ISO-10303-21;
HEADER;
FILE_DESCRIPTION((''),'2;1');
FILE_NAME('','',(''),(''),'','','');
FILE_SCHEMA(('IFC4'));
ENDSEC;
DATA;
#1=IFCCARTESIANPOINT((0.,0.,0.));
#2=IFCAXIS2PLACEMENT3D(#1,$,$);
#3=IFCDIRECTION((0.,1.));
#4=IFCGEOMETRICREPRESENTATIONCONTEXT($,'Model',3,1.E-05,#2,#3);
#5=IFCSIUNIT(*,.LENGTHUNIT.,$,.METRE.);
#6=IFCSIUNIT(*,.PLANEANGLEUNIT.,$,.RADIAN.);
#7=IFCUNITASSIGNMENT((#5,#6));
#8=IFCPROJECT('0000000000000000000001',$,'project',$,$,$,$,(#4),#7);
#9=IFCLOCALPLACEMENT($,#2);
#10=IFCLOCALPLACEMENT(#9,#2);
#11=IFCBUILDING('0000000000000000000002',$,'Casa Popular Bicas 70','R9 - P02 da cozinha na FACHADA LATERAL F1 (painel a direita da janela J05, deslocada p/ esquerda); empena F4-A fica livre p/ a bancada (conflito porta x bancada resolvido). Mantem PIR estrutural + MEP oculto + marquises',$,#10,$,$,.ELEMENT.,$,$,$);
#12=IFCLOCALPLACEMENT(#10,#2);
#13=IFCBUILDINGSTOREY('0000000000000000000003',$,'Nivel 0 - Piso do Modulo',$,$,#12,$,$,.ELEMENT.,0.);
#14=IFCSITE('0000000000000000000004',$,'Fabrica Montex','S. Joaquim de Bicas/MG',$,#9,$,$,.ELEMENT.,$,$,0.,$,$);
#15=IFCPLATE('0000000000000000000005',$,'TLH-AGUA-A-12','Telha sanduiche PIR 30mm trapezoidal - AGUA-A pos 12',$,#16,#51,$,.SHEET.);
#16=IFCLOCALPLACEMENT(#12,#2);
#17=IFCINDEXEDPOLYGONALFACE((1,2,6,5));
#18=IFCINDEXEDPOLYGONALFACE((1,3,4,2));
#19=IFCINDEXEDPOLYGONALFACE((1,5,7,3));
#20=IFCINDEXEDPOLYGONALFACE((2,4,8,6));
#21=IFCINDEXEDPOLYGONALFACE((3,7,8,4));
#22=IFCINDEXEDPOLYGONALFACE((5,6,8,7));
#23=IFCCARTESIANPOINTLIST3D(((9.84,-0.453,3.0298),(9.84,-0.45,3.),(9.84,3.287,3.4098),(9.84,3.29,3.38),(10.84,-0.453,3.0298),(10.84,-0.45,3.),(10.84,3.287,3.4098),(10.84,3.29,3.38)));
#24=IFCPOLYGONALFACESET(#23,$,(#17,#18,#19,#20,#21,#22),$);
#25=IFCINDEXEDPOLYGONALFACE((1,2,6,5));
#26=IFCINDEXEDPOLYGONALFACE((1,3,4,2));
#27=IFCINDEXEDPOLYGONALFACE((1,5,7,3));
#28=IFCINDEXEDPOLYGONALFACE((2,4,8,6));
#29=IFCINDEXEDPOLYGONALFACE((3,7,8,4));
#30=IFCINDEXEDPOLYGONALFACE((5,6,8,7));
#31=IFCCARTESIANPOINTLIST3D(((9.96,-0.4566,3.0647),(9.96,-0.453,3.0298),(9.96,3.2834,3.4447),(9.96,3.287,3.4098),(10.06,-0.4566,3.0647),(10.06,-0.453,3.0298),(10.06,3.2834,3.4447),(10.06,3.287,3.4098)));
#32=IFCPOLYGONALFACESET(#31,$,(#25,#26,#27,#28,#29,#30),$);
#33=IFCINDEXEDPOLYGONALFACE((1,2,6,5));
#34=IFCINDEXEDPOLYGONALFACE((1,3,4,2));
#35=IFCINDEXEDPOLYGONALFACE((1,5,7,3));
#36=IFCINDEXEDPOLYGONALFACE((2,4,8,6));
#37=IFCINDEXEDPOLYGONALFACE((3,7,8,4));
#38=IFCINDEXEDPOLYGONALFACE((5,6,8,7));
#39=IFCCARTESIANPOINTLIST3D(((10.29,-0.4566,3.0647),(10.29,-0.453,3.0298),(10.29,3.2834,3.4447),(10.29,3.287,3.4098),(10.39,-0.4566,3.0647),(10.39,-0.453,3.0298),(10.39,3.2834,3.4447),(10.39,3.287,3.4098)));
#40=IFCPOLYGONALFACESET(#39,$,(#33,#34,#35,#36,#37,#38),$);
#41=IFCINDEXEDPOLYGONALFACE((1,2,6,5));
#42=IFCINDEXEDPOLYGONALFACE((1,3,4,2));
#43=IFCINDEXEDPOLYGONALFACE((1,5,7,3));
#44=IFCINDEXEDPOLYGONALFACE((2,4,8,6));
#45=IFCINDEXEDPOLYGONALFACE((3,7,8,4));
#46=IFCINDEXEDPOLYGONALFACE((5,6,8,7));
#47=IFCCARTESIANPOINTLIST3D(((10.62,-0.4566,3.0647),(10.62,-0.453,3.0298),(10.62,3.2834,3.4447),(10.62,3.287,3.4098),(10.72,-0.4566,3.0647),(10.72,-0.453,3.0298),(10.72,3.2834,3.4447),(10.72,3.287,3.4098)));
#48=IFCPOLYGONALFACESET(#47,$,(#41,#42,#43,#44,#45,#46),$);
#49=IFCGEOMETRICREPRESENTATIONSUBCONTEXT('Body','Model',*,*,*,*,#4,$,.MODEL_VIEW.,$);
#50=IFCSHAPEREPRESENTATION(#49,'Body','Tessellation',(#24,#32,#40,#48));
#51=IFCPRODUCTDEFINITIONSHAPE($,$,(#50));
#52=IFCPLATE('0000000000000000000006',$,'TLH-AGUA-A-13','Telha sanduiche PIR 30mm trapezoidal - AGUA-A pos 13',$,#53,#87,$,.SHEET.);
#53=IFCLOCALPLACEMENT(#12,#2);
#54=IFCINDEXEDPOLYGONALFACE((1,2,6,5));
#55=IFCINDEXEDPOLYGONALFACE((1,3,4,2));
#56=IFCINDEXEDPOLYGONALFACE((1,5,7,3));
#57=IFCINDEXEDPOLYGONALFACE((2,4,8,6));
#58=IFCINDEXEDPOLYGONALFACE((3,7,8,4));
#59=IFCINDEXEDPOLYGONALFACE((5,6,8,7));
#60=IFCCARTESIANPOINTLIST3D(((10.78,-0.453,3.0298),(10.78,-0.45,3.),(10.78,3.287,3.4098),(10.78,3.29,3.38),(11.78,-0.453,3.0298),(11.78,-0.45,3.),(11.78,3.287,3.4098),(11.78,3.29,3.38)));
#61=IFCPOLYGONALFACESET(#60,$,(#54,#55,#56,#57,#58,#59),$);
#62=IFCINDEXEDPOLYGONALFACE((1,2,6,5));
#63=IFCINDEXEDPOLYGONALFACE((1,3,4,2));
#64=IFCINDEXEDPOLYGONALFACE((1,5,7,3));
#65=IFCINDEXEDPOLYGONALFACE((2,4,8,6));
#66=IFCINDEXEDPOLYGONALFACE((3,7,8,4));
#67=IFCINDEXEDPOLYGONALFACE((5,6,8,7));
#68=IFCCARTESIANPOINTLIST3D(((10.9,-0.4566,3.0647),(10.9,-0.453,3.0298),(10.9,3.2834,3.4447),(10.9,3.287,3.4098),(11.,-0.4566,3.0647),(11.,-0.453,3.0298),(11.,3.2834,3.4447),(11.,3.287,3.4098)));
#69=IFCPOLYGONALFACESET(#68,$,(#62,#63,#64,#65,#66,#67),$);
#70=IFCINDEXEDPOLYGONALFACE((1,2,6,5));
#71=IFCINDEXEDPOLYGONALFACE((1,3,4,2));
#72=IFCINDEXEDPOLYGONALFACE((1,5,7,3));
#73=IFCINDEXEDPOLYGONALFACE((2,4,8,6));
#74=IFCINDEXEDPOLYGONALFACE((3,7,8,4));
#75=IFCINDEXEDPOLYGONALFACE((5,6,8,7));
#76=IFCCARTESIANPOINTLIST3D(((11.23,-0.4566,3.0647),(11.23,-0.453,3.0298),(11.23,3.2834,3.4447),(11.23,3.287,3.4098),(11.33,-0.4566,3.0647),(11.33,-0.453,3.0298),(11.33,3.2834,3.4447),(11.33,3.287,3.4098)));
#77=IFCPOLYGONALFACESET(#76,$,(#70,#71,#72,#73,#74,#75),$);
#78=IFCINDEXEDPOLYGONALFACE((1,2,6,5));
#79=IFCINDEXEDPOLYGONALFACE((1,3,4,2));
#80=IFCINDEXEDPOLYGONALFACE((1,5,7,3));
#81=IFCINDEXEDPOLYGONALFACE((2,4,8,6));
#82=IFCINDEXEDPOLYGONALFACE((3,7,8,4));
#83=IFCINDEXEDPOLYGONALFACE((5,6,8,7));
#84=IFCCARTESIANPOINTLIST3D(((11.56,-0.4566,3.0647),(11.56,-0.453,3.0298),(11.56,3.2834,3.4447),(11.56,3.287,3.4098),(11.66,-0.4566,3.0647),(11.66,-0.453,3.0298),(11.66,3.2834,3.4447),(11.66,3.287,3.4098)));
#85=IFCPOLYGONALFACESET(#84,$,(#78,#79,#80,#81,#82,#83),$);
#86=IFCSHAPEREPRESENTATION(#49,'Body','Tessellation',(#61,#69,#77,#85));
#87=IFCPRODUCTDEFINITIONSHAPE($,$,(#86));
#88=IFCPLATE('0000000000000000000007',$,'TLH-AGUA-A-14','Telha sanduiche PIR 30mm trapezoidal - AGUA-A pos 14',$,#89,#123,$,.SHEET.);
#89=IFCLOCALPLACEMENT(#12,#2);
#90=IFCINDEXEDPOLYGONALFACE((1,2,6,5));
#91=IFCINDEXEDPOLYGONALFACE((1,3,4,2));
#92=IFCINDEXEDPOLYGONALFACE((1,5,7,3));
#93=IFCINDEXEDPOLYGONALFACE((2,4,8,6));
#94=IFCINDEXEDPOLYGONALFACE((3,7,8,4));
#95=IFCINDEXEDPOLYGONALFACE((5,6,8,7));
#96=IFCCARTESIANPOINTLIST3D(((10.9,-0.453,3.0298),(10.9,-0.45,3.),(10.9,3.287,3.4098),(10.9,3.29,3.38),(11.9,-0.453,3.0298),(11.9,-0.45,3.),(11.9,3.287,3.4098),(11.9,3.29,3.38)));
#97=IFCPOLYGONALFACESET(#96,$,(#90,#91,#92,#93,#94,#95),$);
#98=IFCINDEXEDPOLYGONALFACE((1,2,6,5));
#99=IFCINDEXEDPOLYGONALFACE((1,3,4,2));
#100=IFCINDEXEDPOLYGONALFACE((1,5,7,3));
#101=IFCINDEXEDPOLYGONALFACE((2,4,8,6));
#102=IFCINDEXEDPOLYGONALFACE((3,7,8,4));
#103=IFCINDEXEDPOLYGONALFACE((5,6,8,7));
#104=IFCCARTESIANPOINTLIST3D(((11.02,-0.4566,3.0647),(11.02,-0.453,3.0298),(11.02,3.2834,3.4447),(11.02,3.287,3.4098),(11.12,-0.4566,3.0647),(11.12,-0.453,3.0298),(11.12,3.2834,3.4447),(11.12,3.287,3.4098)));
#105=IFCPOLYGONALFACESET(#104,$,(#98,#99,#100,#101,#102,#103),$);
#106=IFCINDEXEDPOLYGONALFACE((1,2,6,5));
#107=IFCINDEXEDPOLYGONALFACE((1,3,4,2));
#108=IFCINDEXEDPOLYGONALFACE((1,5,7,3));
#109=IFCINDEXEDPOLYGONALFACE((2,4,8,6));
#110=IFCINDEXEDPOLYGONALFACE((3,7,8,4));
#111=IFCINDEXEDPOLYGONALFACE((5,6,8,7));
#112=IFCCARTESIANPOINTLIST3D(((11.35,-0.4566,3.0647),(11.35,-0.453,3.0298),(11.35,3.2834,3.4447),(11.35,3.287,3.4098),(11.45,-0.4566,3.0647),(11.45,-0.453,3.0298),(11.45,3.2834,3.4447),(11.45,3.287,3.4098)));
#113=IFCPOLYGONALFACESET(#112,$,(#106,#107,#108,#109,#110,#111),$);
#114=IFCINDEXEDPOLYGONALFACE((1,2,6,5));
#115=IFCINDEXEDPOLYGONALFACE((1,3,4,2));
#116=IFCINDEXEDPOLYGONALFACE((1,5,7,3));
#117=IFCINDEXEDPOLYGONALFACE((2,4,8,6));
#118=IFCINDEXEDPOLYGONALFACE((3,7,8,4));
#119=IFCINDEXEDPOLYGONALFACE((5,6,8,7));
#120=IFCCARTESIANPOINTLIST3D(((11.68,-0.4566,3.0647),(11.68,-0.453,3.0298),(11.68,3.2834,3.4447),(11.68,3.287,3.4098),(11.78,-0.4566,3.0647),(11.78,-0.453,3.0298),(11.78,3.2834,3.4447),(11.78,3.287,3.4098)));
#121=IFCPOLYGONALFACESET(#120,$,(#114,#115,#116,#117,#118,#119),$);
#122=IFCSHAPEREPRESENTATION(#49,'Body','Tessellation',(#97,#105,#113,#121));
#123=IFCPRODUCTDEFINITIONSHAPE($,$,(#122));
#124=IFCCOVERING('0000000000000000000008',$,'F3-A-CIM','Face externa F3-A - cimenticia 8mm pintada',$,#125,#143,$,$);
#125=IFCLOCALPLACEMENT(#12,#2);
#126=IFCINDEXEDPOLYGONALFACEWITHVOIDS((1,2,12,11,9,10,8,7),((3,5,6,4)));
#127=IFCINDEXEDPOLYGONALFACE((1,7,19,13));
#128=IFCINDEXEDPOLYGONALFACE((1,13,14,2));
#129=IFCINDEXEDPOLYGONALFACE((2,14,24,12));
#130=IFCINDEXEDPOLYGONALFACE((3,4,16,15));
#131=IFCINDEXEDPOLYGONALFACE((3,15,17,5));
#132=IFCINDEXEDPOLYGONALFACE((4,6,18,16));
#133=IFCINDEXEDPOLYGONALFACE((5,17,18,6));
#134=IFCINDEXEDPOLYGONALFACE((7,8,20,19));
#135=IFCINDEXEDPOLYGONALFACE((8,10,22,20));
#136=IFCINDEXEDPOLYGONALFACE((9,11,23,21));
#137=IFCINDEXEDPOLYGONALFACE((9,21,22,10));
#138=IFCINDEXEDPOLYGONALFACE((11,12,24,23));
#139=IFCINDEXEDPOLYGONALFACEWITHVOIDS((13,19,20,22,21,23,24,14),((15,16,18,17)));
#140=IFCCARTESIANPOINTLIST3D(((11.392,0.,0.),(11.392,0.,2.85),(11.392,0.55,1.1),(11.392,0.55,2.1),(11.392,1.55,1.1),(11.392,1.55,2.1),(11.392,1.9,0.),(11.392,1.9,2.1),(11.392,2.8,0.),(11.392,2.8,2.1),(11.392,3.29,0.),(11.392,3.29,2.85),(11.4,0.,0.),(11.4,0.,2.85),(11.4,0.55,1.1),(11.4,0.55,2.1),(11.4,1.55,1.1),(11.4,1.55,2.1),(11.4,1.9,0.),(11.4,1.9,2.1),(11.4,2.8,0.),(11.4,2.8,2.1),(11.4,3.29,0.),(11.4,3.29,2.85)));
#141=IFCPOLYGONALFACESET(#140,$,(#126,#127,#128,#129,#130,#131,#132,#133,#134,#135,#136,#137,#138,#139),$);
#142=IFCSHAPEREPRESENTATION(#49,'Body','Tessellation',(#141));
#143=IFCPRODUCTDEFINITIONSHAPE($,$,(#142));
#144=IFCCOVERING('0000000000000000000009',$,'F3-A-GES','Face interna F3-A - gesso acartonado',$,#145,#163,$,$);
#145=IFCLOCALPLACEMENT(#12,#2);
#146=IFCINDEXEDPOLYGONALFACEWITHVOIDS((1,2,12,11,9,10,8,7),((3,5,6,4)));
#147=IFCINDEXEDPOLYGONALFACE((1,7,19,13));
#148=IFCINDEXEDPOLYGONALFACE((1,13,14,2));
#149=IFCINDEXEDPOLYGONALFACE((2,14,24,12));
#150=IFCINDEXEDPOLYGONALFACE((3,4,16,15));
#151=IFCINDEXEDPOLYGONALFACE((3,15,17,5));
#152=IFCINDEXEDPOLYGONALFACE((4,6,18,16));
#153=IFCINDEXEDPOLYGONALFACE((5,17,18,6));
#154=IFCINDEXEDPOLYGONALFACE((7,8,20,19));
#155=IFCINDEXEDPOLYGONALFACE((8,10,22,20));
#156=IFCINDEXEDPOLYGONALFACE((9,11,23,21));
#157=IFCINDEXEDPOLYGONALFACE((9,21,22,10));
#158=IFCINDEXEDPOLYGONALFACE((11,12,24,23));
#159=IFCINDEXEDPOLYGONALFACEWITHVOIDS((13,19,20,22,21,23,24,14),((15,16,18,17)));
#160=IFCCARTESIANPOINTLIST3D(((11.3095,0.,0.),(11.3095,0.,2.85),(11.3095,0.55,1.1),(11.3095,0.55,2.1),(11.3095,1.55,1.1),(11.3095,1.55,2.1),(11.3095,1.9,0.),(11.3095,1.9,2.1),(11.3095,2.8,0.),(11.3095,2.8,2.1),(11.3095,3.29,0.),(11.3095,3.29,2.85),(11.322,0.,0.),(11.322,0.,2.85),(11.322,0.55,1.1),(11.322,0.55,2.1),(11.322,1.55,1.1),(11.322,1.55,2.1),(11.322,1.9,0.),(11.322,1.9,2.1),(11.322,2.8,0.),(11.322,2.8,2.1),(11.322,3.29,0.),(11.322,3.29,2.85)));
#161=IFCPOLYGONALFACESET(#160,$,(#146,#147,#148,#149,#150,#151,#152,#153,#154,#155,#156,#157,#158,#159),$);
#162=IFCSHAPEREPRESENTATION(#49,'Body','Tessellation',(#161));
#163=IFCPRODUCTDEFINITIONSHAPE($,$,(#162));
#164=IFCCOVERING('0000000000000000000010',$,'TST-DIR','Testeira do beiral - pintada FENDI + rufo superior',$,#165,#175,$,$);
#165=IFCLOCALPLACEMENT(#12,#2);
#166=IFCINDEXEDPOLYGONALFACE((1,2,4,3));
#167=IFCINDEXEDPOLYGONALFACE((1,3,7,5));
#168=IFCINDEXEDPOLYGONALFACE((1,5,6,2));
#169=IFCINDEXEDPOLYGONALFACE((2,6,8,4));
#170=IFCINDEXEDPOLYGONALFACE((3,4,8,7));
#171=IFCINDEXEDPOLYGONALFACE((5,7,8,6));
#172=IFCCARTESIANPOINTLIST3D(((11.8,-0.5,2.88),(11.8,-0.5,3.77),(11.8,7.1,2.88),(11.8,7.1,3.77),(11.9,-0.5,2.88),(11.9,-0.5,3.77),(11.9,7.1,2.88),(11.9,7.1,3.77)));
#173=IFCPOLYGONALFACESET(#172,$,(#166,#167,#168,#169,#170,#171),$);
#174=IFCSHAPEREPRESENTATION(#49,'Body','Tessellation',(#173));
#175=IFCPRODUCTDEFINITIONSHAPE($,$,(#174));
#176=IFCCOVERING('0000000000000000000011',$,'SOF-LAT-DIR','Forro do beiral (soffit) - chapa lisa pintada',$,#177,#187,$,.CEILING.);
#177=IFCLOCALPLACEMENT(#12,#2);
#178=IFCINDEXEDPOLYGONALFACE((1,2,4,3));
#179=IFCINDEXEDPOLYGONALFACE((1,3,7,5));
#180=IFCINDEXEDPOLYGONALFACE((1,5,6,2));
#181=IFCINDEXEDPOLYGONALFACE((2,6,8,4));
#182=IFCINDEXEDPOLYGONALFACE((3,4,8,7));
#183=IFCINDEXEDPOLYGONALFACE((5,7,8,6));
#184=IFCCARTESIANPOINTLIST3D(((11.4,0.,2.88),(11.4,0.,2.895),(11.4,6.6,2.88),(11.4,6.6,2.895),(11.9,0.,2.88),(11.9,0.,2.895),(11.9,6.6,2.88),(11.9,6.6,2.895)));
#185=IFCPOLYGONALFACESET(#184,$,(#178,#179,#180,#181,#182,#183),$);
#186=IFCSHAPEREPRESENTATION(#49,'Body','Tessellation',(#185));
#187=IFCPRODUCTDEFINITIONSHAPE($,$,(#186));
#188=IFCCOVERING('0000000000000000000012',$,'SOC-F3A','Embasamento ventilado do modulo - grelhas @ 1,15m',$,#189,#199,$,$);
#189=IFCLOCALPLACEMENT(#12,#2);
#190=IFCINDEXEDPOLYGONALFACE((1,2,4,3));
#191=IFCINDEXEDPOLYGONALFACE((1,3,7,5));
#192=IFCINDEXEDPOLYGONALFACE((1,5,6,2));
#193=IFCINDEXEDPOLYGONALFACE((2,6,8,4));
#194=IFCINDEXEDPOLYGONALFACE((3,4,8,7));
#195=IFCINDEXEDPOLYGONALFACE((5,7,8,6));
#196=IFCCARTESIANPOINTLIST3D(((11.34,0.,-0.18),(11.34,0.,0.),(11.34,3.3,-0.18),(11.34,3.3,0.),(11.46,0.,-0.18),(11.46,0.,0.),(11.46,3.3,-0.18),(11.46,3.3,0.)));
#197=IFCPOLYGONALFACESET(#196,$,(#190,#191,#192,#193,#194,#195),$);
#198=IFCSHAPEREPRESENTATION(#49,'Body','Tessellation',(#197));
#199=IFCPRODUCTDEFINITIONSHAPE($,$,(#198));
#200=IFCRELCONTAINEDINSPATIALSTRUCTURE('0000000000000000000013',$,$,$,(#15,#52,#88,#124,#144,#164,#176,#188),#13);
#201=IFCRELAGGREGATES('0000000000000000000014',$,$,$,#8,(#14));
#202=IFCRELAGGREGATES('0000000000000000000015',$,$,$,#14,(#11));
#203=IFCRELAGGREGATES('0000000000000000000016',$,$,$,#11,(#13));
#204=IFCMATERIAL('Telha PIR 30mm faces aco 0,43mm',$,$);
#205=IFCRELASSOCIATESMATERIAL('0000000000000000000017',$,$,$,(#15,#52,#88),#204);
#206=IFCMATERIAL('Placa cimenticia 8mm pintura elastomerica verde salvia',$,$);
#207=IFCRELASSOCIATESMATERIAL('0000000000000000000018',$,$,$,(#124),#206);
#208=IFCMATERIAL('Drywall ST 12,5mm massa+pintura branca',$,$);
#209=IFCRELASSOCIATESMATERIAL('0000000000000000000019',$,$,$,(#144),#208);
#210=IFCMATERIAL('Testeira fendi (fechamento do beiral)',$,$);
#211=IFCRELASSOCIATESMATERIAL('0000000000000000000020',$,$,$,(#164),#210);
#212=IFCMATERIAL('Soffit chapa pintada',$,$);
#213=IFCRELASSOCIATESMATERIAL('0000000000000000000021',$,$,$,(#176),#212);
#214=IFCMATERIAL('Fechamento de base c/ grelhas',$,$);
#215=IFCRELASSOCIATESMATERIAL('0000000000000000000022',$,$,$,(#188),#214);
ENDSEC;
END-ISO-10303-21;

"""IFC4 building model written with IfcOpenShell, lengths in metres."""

from ifc_helpers import new_model, si_unit, direction, frame, frame_2d, origin, origin_2d, place, context, subcontext, project, spatial, rectangle, extrude, material, element, save


model = new_model("IFC4")

# Units and contexts
model_context = context("Model", 3, precision=1e-05, world=origin(), true_north=direction((0.0, 1.0)))
body_context = subcontext(model_context, "Body", "Model", "MODEL_VIEW")
ifc_project = project(units=[si_unit("LENGTHUNIT", "METRE"), si_unit("PLANEANGLEUNIT", "RADIAN")], contexts=[model_context])

# Site, building, storey
site_placement = place(None, origin())
site = spatial("IfcSite", under=ifc_project, at=site_placement, Name="Fabrica Montex", Description="S. Joaquim de Bicas/MG", CompositionType="ELEMENT", RefElevation=0.0)
building_placement = place(site_placement, origin())
building = spatial("IfcBuilding", under=site, at=building_placement, Name="Casa Popular Bicas 70", Description="R9 - P02 da cozinha na FACHADA LATERAL F1 (painel a direita da janela J05, deslocada p/ esquerda); empena F4-A fica livre p/ a bancada (conflito porta x bancada resolvido). Mantem PIR estrutural + MEP oculto + marquises", CompositionType="ELEMENT")
storey_placement = place(building_placement, origin())
storey = spatial("IfcBuildingStorey", under=building, at=storey_placement, Name="Nivel 0 - Piso do Modulo", CompositionType="ELEMENT", Elevation=0.0)

# Plates
ifc_material_1 = material(Name="Telha PIR 30mm faces aco 0,43mm")
for number, where, z_axis, x_axis, name, description in (
    (1, (9.84, -0.45, 3.0), (0.0, -0.101084, 0.994878), (1.0, 0.0, 0.0), "TLH-AGUA-A-12", "Telha sanduiche PIR 30mm trapezoidal - AGUA-A pos 12"),
    (2, (10.78, -0.45, 3.0), (0.0, -0.101084, 0.994878), (1.0, 0.0, 0.0), "TLH-AGUA-A-13", "Telha sanduiche PIR 30mm trapezoidal - AGUA-A pos 13"),
    (3, (10.9, -0.45, 3.0), (0.0, -0.101084, 0.994878), (1.0, 0.0, 0.0), "TLH-AGUA-A-14", "Telha sanduiche PIR 30mm trapezoidal - AGUA-A pos 14"),
):
    element("IfcPlate", number, at=place(storey_placement, frame(where, z_axis=z_axis, x_axis=x_axis)), inside=storey, material=ifc_material_1, Name=name, Description=description, PredefinedType="SHEET", context=body_context, shape_type="SweptSolid", body=[
        extrude(rectangle(XDim=1.0, YDim=3.7593, at=frame_2d((0.5, 1.8796))), origin(), (0.0, 0.0, 1.0), 0.03),
        extrude(rectangle(XDim=0.1, YDim=3.7593, at=frame_2d((0.17, 1.8796))), frame((0.0, 0.0, 0.03)), (0.0, 0.0, 1.0), 0.035),
        extrude(rectangle(XDim=0.1, YDim=3.7593, at=frame_2d((0.5, 1.8796))), frame((0.0, 0.0, 0.03)), (0.0, 0.0, 1.0), 0.035),
        extrude(rectangle(XDim=0.1, YDim=3.7593, at=frame_2d((0.83, 1.8796))), frame((0.0, 0.0, 0.03)), (0.0, 0.0, 1.0), 0.035),
    ])

# Coverings, openings
ifc_material_2 = material(Name="Placa cimenticia 8mm pintura elastomerica verde salvia")
covering_1_placement = place(storey_placement, frame((11.396, 0.0, 0.0), x_axis=(0.0, 1.0, 0.0)))
covering_1 = element("IfcCovering", 4, at=covering_1_placement, inside=storey, material=ifc_material_2, Name="F3-A-CIM", Description="Face externa F3-A - cimenticia 8mm pintada", context=body_context, shape_type="SweptSolid", body=[
    extrude(rectangle(XDim=3.29, YDim=0.008, at=frame_2d((1.645, 0.0))), origin(), (0.0, 0.0, 1.0), 2.85),
])
opening_1_placement = place(storey_placement, frame((11.396, 1.05, 1.1)))
element("IfcOpeningElement", 5, at=opening_1_placement, cuts=covering_1, PredefinedType="OPENING", context=body_context, shape_type="SweptSolid", body=[
    extrude(rectangle(XDim=0.038, YDim=1.0, at=origin_2d()), origin(), (0.0, 0.0, 1.0), 1.0),
])
opening_2_placement = place(storey_placement, frame((11.396, 2.35, 0.0)))
element("IfcOpeningElement", 6, at=opening_2_placement, cuts=covering_1, PredefinedType="OPENING", context=body_context, shape_type="SweptSolid", body=[
    extrude(rectangle(XDim=0.038, YDim=0.9, at=origin_2d()), origin(), (0.0, 0.0, 1.0), 2.1),
])
ifc_material_3 = material(Name="Drywall ST 12,5mm massa+pintura branca")
covering_2_placement = place(storey_placement, frame((11.3157, 0.0, 0.0), x_axis=(0.0, 1.0, 0.0)))
covering_2 = element("IfcCovering", 7, at=covering_2_placement, inside=storey, material=ifc_material_3, Name="F3-A-GES", Description="Face interna F3-A - gesso acartonado", context=body_context, shape_type="SweptSolid", body=[
    extrude(rectangle(XDim=3.29, YDim=0.0125, at=frame_2d((1.645, 0.0))), origin(), (0.0, 0.0, 1.0), 2.85),
])
opening_3_placement = place(storey_placement, frame((11.3157, 1.05, 1.1)))
element("IfcOpeningElement", 8, at=opening_3_placement, cuts=covering_2, PredefinedType="OPENING", context=body_context, shape_type="SweptSolid", body=[
    extrude(rectangle(XDim=0.0425, YDim=1.0, at=origin_2d()), origin(), (0.0, 0.0, 1.0), 1.0),
])
opening_4_placement = place(storey_placement, frame((11.3157, 2.35, 0.0)))
element("IfcOpeningElement", 9, at=opening_4_placement, cuts=covering_2, PredefinedType="OPENING", context=body_context, shape_type="SweptSolid", body=[
    extrude(rectangle(XDim=0.0425, YDim=0.9, at=origin_2d()), origin(), (0.0, 0.0, 1.0), 2.1),
])

# Coverings
ifc_material_4 = material(Name="Testeira fendi (fechamento do beiral)")
covering_3_placement = place(storey_placement, frame((11.85, -0.5, 2.88), x_axis=(0.0, 1.0, 0.0)))
element("IfcCovering", 10, at=covering_3_placement, inside=storey, material=ifc_material_4, Name="TST-DIR", Description="Testeira do beiral - pintada FENDI + rufo superior", context=body_context, shape_type="SweptSolid", body=[
    extrude(rectangle(XDim=7.6, YDim=0.1, at=frame_2d((3.8, 0.0))), origin(), (0.0, 0.0, 1.0), 0.89),
])
ifc_material_5 = material(Name="Soffit chapa pintada")
covering_4_placement = place(storey_placement, frame((11.4, 0.0, 2.88)))
element("IfcCovering", 11, at=covering_4_placement, inside=storey, material=ifc_material_5, Name="SOF-LAT-DIR", Description="Forro do beiral (soffit) - chapa lisa pintada", PredefinedType="CEILING", context=body_context, shape_type="SweptSolid", body=[
    extrude(rectangle(XDim=0.5, YDim=6.6, at=frame_2d((0.25, 3.3))), origin(), (0.0, 0.0, 1.0), 0.015),
])
ifc_material_6 = material(Name="Fechamento de base c/ grelhas")
covering_5_placement = place(storey_placement, frame((11.4, 0.0, -0.18), x_axis=(0.0, 1.0, 0.0)))
element("IfcCovering", 12, at=covering_5_placement, inside=storey, material=ifc_material_6, Name="SOC-F3A", Description="Embasamento ventilado do modulo - grelhas @ 1,15m", context=body_context, shape_type="SweptSolid", body=[
    extrude(rectangle(XDim=3.3, YDim=0.12, at=frame_2d((1.65, 0.0))), origin(), (0.0, 0.0, 1.0), 0.18),
])

save(model, "model.ifc")
